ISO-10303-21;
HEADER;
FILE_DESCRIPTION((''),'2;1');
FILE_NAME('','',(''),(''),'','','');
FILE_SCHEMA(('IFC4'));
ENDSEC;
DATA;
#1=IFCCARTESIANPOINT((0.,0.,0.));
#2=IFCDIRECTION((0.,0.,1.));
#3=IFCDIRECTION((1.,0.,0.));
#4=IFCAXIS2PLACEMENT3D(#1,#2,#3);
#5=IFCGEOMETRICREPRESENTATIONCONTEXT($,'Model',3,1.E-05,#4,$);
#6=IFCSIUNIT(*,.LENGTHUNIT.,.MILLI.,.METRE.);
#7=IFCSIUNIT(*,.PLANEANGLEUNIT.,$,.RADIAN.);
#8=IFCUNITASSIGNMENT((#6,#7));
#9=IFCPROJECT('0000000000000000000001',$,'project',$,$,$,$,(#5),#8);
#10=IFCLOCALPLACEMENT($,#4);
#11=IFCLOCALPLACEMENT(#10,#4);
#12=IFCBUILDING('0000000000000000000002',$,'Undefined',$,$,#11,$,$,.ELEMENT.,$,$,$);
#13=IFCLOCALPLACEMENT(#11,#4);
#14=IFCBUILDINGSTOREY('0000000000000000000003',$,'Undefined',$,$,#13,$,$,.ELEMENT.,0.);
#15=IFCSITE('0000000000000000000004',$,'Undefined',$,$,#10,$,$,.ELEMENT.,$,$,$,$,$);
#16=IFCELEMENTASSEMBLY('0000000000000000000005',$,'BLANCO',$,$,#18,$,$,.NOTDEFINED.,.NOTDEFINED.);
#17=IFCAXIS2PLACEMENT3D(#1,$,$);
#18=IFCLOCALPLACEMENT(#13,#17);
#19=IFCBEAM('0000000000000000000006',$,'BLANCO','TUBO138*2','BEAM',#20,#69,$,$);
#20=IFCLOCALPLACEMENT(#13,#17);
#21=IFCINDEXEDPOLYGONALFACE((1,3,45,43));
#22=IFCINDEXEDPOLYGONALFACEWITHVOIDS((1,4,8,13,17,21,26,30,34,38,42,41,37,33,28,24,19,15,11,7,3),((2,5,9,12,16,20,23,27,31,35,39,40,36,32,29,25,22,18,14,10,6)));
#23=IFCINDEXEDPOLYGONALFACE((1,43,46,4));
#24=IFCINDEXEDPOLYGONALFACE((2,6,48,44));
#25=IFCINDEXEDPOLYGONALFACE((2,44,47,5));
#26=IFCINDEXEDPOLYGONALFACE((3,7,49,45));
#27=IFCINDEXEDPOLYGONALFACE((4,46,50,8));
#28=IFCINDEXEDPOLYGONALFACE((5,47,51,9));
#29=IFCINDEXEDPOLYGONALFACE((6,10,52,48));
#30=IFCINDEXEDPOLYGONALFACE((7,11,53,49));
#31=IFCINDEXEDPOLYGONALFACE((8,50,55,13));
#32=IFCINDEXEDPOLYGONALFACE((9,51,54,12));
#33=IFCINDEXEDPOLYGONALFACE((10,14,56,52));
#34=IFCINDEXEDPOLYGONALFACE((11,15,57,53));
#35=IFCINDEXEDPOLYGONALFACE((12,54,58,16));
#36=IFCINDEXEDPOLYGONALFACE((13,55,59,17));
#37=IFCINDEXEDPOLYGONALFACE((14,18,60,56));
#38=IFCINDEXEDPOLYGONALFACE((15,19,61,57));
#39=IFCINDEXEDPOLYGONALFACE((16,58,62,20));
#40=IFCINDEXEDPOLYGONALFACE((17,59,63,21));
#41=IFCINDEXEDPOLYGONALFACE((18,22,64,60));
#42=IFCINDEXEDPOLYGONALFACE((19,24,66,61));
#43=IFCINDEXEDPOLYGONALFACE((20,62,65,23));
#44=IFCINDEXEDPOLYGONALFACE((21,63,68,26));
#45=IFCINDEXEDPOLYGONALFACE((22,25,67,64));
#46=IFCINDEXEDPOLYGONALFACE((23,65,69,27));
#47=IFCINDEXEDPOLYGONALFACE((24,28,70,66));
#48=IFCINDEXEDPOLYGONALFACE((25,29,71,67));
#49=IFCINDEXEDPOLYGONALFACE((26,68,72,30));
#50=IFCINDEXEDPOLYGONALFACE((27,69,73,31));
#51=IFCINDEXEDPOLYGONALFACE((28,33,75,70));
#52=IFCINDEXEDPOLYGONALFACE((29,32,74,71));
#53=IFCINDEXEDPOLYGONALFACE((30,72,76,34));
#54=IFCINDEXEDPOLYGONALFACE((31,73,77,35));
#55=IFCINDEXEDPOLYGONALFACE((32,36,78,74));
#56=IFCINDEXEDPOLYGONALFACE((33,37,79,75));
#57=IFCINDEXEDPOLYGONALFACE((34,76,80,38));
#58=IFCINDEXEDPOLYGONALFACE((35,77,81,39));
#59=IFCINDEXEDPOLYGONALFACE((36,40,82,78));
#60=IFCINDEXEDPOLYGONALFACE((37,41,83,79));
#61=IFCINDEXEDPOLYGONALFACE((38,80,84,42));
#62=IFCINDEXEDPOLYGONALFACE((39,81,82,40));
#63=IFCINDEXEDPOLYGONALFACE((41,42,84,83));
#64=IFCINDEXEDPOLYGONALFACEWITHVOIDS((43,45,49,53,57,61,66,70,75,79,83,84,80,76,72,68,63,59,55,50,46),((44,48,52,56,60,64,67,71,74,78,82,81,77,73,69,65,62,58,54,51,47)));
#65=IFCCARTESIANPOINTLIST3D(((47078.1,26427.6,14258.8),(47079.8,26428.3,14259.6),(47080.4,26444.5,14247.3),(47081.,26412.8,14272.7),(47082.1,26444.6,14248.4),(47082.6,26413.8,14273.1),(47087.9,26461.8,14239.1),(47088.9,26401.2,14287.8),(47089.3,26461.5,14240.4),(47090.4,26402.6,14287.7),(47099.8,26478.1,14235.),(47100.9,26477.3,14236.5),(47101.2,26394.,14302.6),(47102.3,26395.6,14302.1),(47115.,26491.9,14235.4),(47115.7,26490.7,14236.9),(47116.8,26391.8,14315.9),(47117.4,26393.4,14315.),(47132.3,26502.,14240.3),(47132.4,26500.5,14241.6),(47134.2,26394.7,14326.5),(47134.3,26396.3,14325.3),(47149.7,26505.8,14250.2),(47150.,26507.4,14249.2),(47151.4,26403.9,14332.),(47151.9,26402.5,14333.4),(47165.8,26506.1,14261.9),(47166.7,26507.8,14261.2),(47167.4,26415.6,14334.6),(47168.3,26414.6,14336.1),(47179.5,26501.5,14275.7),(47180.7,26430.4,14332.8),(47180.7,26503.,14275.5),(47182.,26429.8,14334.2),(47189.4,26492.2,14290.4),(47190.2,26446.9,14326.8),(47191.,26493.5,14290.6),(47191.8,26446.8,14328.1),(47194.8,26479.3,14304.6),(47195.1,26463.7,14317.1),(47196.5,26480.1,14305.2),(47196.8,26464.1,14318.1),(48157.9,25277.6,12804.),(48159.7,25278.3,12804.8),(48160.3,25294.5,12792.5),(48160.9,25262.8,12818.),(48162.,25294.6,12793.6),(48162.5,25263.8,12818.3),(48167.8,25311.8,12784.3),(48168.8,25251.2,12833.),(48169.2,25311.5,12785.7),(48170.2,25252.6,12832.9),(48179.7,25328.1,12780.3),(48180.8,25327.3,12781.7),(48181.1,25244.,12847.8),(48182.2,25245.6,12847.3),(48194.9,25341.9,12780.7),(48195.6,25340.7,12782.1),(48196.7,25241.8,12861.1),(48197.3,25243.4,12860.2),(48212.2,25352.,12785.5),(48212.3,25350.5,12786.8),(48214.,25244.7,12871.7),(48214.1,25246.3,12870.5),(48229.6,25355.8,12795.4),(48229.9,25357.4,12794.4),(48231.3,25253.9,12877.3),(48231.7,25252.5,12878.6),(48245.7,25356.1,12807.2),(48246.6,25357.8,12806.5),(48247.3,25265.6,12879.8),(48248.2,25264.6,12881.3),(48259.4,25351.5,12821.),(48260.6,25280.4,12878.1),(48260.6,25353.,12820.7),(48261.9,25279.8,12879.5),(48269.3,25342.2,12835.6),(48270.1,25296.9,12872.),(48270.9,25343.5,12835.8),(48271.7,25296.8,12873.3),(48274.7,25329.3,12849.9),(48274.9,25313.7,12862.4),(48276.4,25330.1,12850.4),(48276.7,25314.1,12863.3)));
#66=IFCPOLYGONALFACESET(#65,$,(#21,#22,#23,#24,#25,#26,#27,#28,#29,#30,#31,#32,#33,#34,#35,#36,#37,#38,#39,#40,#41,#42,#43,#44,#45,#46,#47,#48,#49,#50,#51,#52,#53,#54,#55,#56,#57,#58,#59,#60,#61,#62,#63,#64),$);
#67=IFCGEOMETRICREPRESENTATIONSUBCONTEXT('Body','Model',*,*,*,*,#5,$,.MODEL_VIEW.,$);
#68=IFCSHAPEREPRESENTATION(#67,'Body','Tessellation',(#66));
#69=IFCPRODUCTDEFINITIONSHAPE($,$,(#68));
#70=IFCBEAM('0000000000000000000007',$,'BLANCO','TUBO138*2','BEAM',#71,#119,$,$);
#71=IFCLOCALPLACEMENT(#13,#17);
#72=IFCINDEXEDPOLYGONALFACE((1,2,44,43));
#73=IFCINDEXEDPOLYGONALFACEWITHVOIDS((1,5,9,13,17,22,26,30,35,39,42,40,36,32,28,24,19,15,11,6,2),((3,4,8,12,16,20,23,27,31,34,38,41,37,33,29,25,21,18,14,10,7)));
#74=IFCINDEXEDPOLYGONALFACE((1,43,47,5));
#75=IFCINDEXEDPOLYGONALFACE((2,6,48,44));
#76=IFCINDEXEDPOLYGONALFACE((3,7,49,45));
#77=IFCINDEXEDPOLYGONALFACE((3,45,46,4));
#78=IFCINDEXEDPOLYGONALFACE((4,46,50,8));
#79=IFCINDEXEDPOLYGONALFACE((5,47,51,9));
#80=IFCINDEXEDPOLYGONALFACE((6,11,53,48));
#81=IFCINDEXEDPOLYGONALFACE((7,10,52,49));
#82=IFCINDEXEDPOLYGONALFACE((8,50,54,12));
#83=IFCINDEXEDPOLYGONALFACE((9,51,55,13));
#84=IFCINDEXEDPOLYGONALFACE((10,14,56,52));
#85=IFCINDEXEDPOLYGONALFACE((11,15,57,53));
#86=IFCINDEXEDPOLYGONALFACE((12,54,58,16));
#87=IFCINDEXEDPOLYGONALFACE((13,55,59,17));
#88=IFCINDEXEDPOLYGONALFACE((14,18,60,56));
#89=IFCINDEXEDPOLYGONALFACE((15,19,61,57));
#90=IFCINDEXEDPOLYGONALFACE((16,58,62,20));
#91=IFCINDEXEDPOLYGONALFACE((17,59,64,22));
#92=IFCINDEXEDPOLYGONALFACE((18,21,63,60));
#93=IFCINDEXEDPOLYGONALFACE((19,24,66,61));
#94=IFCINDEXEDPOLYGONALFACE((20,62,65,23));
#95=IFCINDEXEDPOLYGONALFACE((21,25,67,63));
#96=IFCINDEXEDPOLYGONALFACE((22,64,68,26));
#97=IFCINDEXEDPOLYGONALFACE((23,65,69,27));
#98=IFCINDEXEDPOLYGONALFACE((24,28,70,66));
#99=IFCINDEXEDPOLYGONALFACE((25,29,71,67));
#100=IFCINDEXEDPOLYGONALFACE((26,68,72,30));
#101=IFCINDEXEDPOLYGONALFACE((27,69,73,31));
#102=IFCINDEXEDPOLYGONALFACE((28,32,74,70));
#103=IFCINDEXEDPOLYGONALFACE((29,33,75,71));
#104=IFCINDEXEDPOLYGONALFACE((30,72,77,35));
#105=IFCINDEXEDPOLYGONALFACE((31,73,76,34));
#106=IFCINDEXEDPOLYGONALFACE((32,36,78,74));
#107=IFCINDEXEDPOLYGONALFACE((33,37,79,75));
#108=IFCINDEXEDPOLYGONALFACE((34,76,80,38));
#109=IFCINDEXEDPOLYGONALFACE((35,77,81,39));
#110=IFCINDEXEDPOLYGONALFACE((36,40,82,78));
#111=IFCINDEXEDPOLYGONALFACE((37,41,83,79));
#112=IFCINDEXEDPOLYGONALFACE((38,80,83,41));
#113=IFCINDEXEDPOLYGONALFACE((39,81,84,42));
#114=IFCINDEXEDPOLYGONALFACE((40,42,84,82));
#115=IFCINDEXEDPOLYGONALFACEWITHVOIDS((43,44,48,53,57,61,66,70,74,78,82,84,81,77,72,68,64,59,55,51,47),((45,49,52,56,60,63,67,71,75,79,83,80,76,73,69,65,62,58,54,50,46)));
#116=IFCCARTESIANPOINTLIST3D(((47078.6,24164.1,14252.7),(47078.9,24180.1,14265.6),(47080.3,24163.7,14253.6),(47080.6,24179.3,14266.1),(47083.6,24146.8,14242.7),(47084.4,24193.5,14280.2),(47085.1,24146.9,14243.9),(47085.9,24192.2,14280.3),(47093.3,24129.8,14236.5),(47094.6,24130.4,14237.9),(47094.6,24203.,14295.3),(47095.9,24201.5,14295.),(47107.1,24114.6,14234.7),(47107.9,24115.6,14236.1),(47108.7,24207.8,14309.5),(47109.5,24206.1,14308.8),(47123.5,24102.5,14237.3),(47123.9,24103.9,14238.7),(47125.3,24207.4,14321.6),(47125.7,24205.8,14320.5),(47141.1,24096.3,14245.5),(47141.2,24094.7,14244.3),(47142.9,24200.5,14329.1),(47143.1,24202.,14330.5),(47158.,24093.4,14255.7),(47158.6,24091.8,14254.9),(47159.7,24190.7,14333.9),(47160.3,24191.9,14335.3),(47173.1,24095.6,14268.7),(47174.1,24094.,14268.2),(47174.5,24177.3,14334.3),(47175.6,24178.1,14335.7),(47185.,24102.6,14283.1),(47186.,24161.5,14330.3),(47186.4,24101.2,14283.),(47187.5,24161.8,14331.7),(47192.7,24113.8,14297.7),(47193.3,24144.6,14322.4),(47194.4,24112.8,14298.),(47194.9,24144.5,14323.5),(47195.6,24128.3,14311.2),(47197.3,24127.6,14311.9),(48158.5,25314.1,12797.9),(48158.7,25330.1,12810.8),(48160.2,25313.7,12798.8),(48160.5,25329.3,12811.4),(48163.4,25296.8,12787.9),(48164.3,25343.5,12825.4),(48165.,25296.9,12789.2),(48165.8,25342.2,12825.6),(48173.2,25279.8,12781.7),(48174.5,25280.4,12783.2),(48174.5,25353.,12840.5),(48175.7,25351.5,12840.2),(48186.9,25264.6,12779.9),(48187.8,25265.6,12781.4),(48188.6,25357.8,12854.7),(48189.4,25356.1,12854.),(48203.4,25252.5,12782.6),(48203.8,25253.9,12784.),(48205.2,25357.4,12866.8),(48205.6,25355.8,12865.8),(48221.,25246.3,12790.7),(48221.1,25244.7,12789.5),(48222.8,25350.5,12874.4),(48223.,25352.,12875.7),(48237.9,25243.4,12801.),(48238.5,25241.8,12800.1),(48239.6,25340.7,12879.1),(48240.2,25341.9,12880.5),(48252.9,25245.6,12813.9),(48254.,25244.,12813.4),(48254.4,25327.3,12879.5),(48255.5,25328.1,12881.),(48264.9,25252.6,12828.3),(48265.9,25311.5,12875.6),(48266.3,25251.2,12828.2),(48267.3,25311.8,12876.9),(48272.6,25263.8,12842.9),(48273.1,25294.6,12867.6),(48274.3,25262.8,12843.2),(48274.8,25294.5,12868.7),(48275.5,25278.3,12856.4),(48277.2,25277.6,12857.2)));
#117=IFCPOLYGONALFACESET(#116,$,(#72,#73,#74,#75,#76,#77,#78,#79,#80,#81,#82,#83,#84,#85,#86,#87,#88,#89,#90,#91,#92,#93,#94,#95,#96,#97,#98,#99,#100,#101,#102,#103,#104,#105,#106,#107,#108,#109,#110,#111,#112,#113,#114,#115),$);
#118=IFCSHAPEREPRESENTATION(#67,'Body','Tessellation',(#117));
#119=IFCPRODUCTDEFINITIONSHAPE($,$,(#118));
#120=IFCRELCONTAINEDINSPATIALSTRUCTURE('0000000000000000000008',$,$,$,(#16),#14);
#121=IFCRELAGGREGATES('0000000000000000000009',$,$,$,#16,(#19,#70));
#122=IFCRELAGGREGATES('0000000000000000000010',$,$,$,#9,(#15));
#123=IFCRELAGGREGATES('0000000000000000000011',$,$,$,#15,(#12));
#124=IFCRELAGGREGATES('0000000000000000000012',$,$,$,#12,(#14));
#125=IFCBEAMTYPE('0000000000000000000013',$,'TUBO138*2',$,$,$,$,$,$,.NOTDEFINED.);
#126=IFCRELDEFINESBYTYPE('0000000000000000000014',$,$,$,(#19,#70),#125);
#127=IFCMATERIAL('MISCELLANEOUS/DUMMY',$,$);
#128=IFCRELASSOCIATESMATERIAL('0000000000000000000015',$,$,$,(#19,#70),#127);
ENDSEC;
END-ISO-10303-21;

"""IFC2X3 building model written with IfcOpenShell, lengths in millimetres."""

from ifc_helpers import new_model, si_unit, frame, origin_with_axes, origin_2d_with_axis, place, context, subcontext, project, spatial, hollow_circle, extrude, material, type_object, element, aggregate, save


model = new_model("IFC2X3")

# Units and contexts
model_context = context("Model", 3, precision=1e-05, world=origin_with_axes())
body_context = subcontext(model_context, "Body", "Model", "MODEL_VIEW")
ifc_project = project(units=[si_unit("LENGTHUNIT", "METRE", prefix="MILLI"), si_unit("PLANEANGLEUNIT", "RADIAN")], contexts=[model_context])

# Site, building, storey
site_placement = place(None, origin_with_axes())
site = spatial("IfcSite", under=ifc_project, at=site_placement, Name="Undefined", CompositionType="ELEMENT")
building_placement = place(site_placement, origin_with_axes())
building = spatial("IfcBuilding", under=site, at=building_placement, Name="Undefined", CompositionType="ELEMENT")
storey_placement = place(building_placement, origin_with_axes())
storey = spatial("IfcBuildingStorey", under=building, at=storey_placement, Name="Undefined", CompositionType="ELEMENT", Elevation=0.0)

# Element assembly, beams
assembly_placement = place(storey_placement, origin_with_axes())
assembly = element("IfcElementAssembly", 1, at=assembly_placement, inside=storey, Name="BLANCO", AssemblyPlace="NOTDEFINED", PredefinedType="NOTDEFINED")
ifc_material = material(Name="MISCELLANEOUS/DUMMY")
beam_type = type_object("IfcBeamType", Name="TUBO138*2", PredefinedType="NOTDEFINED")
beam_1_placement = place(assembly_placement, frame((48217.6, 25300.0, 12830.6), z_axis=(-0.497966, 0.461316, -0.734314), x_axis=(-0.503224, 0.535899, 0.677922)))
beam_1 = element("IfcBeam", 2, at=beam_1_placement, type_object=beam_type, material=ifc_material, Name="BLANCO", Description="TUBO138*2", ObjectType="BEAM", context=body_context, shape_type="SweptSolid", body=[
    extrude(hollow_circle(Radius=69.0, WallThickness=2.0, at=origin_2d_with_axis()), frame((2145.9, 0.0, 0.0), z_axis=(-1.0, 0.0, 0.0), x_axis=(0.0, -1.0, 0.0)), (0.0, 0.0, 1.0), 2145.9),
])
beam_2_placement = place(assembly_placement, frame((48217.6, 25300.0, 12830.6), z_axis=(-0.497966, -0.461316, -0.734314), x_axis=(-0.503224, -0.535899, 0.677922)))
beam_2 = element("IfcBeam", 3, at=beam_2_placement, type_object=beam_type, material=ifc_material, Name="BLANCO", Description="TUBO138*2", ObjectType="BEAM", context=body_context, shape_type="SweptSolid", body=[
    extrude(hollow_circle(Radius=69.0, WallThickness=2.0, at=origin_2d_with_axis()), frame((2145.9, 0.0, 0.0), z_axis=(-1.0, 0.0, 0.0), x_axis=(0.0, -1.0, 0.0)), (0.0, 0.0, 1.0), 2145.9),
])
aggregate(assembly, [beam_1, beam_2])

save(model, "model.ifc")
